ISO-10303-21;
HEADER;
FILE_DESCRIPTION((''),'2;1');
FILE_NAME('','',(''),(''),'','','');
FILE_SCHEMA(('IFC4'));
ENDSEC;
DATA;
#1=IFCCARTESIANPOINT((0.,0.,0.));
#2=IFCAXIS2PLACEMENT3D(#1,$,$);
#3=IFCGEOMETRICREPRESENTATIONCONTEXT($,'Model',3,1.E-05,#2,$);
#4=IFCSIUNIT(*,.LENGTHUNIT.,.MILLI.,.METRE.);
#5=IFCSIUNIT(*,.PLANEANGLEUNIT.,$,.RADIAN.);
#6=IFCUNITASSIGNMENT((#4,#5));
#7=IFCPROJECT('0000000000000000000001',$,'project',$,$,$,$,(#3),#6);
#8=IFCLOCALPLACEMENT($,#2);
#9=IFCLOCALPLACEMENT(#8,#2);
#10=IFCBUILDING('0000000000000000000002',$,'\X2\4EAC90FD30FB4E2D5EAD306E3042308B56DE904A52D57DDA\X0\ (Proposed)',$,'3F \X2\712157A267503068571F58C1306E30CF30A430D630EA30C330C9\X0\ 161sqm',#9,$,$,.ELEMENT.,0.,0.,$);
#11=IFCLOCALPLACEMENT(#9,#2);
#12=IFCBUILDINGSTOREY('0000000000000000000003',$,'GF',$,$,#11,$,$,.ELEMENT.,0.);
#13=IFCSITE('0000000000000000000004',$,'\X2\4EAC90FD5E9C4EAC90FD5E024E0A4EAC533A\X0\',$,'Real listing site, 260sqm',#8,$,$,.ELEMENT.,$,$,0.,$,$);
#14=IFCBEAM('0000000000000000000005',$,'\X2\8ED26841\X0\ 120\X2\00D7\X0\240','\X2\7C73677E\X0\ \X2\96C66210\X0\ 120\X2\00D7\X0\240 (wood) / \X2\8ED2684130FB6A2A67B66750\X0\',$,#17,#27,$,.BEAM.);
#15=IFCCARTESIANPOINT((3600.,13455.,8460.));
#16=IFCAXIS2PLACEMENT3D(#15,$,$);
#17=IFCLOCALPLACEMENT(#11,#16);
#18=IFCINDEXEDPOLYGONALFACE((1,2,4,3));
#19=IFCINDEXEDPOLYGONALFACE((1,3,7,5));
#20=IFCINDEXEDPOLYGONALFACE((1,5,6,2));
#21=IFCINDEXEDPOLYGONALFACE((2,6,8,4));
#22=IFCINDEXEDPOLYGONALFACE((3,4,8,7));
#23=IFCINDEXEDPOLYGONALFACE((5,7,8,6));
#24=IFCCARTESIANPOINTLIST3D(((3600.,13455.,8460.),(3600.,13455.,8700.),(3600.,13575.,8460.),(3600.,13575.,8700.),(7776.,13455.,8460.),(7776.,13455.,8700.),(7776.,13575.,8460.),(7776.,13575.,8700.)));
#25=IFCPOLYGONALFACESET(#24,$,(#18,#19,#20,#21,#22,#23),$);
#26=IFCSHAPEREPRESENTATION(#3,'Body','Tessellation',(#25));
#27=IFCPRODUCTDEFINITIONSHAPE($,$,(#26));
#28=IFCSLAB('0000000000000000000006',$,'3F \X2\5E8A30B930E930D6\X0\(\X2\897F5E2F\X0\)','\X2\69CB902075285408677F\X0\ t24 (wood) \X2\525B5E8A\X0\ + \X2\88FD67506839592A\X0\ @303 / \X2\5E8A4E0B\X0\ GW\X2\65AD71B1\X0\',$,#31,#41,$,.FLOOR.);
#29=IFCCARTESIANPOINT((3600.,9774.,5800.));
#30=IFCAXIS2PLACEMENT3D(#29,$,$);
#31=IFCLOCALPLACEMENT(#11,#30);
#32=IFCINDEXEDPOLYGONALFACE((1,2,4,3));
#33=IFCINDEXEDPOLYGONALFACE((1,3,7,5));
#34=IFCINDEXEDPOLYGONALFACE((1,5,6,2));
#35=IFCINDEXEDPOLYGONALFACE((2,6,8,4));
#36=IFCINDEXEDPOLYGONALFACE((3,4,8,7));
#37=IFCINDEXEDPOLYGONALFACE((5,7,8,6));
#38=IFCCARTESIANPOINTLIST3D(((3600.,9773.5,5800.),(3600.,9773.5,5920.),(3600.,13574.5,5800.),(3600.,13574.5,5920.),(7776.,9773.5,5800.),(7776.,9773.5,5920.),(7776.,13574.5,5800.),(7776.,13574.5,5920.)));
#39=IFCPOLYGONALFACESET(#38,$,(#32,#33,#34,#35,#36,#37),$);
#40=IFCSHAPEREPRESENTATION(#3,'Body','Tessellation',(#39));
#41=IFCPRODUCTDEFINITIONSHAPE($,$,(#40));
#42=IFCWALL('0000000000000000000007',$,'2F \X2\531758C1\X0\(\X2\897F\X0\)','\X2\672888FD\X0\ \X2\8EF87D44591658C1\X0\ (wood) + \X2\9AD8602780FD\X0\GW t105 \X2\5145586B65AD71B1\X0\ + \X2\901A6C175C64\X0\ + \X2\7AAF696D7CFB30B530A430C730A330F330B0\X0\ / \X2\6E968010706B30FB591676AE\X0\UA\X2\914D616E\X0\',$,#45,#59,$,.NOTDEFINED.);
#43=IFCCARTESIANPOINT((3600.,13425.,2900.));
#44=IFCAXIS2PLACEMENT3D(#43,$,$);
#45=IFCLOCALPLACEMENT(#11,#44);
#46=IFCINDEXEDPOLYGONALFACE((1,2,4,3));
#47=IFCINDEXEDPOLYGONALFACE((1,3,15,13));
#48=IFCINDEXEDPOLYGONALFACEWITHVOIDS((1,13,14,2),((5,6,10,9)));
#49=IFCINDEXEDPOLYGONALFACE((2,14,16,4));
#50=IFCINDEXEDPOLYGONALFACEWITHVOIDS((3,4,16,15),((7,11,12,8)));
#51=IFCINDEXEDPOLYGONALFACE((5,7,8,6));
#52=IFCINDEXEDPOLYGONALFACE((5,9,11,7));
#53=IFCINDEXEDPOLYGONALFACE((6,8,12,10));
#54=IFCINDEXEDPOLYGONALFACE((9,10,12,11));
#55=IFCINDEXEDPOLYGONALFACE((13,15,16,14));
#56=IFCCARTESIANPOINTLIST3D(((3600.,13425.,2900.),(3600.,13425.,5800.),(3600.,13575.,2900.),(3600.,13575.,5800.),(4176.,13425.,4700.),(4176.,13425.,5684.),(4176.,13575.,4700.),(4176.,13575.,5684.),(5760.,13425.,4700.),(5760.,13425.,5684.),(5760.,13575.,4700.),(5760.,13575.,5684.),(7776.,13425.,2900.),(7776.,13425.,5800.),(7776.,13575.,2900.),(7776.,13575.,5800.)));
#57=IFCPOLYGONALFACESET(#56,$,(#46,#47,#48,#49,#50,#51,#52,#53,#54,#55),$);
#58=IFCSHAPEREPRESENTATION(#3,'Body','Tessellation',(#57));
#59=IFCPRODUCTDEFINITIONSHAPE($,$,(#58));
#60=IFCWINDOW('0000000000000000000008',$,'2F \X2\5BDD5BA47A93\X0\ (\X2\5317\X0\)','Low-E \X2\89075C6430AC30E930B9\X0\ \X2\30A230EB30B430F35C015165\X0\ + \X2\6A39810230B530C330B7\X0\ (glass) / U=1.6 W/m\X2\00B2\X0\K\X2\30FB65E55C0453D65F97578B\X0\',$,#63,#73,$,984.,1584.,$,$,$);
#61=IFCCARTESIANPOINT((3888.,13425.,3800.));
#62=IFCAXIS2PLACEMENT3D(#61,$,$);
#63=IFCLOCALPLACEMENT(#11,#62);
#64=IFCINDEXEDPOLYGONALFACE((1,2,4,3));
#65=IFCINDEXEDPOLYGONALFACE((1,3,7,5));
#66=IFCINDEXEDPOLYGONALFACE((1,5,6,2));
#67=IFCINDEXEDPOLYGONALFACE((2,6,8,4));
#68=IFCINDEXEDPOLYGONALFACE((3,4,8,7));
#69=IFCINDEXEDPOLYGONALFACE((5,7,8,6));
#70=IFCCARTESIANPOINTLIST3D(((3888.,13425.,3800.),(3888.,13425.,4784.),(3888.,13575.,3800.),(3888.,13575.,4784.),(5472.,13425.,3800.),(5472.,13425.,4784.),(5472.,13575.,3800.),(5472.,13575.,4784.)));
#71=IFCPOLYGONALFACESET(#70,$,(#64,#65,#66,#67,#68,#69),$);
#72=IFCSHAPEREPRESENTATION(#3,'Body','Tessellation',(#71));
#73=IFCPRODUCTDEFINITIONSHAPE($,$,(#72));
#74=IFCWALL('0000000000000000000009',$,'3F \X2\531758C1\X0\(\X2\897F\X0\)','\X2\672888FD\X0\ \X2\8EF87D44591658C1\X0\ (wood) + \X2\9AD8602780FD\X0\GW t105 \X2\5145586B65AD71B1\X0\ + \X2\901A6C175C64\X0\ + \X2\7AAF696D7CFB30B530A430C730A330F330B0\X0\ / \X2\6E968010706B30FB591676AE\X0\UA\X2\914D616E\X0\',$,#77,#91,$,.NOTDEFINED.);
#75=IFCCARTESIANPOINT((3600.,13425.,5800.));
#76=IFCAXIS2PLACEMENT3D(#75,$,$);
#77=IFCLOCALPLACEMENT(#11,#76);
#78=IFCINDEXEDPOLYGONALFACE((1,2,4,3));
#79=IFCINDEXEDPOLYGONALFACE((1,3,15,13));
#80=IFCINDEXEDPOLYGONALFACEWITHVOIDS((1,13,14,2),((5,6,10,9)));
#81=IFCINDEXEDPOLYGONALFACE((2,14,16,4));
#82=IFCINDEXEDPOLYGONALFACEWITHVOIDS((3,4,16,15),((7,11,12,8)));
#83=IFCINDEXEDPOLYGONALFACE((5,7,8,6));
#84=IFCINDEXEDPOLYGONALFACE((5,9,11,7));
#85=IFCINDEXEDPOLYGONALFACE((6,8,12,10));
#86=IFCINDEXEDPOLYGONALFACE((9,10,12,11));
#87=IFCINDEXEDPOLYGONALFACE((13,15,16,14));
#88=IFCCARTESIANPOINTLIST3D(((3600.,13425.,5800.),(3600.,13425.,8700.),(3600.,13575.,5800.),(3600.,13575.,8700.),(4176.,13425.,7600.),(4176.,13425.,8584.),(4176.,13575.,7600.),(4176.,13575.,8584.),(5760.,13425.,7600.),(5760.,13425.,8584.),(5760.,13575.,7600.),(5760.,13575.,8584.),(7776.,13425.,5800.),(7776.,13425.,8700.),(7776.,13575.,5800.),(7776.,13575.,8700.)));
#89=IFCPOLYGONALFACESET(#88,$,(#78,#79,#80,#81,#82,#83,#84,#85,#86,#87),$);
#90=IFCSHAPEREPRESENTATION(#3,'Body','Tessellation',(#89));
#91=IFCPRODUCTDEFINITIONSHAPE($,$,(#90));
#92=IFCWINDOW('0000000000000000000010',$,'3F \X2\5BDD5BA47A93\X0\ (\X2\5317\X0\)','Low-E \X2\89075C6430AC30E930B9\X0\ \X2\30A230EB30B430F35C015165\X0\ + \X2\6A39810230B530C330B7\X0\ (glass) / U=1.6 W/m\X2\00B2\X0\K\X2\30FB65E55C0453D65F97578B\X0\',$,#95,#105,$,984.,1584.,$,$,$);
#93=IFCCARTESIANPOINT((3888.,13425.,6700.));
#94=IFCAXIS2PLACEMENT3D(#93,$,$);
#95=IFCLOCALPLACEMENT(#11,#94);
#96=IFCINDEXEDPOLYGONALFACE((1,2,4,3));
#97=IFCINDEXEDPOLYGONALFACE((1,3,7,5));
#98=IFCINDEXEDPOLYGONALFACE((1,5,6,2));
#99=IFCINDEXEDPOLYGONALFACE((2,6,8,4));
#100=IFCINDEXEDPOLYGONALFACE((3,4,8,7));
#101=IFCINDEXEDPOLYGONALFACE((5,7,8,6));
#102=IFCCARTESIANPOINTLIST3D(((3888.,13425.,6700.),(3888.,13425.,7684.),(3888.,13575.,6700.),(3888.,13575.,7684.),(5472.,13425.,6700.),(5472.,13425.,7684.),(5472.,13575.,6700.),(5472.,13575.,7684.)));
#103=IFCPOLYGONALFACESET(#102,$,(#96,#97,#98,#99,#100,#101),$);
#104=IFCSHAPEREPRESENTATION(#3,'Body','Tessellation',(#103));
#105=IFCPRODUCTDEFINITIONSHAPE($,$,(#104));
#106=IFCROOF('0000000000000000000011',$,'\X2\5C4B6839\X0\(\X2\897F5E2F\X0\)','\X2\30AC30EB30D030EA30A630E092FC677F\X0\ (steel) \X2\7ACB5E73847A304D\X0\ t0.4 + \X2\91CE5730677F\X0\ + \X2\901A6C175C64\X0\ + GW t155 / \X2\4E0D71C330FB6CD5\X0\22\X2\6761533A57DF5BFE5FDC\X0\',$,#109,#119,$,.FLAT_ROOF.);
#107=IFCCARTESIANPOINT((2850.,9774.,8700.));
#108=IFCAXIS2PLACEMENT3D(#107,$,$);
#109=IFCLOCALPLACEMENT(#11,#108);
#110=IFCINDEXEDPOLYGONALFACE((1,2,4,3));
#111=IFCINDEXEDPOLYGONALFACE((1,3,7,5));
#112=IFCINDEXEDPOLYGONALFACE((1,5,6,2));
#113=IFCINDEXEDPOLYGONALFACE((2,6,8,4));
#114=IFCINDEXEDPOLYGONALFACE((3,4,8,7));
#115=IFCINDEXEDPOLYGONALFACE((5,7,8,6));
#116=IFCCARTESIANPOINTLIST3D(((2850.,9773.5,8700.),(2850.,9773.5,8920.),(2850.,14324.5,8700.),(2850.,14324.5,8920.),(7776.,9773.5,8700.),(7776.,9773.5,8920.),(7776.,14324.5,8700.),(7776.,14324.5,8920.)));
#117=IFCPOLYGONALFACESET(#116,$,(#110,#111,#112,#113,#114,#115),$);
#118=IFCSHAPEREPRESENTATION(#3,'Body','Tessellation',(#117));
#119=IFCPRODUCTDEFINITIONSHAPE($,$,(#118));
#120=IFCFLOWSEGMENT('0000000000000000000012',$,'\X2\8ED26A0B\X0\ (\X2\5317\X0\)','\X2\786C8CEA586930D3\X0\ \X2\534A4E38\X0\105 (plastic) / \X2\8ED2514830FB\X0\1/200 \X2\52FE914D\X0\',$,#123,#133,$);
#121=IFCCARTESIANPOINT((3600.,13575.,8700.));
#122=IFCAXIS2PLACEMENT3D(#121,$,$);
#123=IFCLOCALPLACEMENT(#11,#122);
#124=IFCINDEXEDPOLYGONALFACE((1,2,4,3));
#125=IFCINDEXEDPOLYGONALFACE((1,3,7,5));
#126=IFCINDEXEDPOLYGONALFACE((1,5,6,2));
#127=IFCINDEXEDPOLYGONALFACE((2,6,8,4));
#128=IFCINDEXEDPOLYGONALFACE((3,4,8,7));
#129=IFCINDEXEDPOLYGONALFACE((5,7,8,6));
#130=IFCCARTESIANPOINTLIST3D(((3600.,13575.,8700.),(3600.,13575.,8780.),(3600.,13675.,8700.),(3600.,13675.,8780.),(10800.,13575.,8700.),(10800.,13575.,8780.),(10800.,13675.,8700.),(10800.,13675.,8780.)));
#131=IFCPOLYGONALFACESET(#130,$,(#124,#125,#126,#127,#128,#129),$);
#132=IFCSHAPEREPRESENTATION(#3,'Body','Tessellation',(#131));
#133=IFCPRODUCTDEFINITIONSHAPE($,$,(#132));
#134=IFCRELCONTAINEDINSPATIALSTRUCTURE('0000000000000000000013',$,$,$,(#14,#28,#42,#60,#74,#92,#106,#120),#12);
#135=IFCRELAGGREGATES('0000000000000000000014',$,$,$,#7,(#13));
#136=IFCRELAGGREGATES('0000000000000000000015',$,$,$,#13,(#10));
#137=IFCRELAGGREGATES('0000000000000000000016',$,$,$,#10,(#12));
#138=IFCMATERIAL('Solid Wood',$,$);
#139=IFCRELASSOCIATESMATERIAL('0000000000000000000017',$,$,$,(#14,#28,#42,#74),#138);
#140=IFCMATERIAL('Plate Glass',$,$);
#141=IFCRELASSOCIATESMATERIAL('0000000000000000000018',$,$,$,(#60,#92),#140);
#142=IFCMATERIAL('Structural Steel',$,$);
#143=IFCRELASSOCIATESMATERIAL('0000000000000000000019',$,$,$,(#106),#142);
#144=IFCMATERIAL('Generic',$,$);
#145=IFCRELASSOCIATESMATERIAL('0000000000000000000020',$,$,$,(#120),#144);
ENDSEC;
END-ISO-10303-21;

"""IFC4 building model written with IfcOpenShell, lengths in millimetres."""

from ifc_helpers import new_model, si_unit, frame, frame_2d, origin, place, context, project, spatial, rectangle, extrude, material, element, fill, save


model = new_model("IFC4")

# Units and contexts
model_context = context("Model", 3, precision=1e-05, world=origin())
ifc_project = project(units=[si_unit("LENGTHUNIT", "METRE", prefix="MILLI"), si_unit("PLANEANGLEUNIT", "RADIAN")], contexts=[model_context])

# Site, building, storey
site_placement = place(None, origin())
site = spatial("IfcSite", under=ifc_project, at=site_placement, Name="京都府京都市上京区", ObjectType="Real listing site, 260sqm", CompositionType="ELEMENT", RefElevation=0.0)
building_placement = place(site_placement, origin())
building = spatial("IfcBuilding", under=site, at=building_placement, Name="京都・中庭のある回遊動線 (Proposed)", ObjectType="3F 無垢材と土壁のハイブリッド 161sqm", CompositionType="ELEMENT", ElevationOfRefHeight=0.0, ElevationOfTerrain=0.0)
storey_placement = place(building_placement, origin())
storey = spatial("IfcBuildingStorey", under=building, at=storey_placement, Name="GF", CompositionType="ELEMENT", Elevation=0.0)

# Shared definitions
ifc_material_1 = material(Name="Solid Wood")

# Beam
beam_1_placement = place(storey_placement, frame((3600.0, 13455.0, 8460.0)))
element("IfcBeam", 1, at=beam_1_placement, inside=storey, material=ifc_material_1, Name="軒桁 120×240", Description="米松 集成 120×240 (wood) / 軒桁・横架材", PredefinedType="BEAM", context=model_context, shape_type="SweptSolid", body=[
    extrude(rectangle(XDim=4176.0, YDim=120.0, at=frame_2d((2088.0, 60.0))), frame((3600.0, 13455.0, 8460.0)), (0.0, 0.0, 1.0), 240.0),
])

# Slab
slab_placement = place(storey_placement, frame((3600.0, 9774.0, 5800.0)))
element("IfcSlab", 2, at=slab_placement, inside=storey, material=ifc_material_1, Name="3F 床スラブ(西帯)", Description="構造用合板 t24 (wood) 剛床 + 製材根太 @303 / 床下 GW断熱", PredefinedType="FLOOR", context=model_context, shape_type="SweptSolid", body=[
    extrude(rectangle(XDim=4176.0, YDim=3801.0, at=frame_2d((2088.0, 1900.0))), frame((3600.0, 9774.0, 5800.0)), (0.0, 0.0, 1.0), 120.0),
])

# Walls, openings, windows
wall_1_placement = place(storey_placement, frame((3600.0, 13425.0, 2900.0)))
wall_1 = element("IfcWall", 3, at=wall_1_placement, inside=storey, material=ifc_material_1, Name="2F 北壁(西)", Description="木製 軸組外壁 (wood) + 高性能GW t105 充填断熱 + 通気層 + 窯業系サイディング / 準耐火・外皮UA配慮", PredefinedType="NOTDEFINED", context=model_context, shape_type="SweptSolid", body=[
    extrude(rectangle(XDim=4176.0, YDim=150.0, at=frame_2d((2088.0, 75.0))), frame((3600.0, 13425.0, 2900.0)), (0.0, 0.0, 1.0), 2900.0),
])
opening_1_placement = place(storey_placement, frame((3888.0, 13425.0, 3800.0)))
opening_1 = element("IfcOpeningElement", 4, at=opening_1_placement, cuts=wall_1, PredefinedType="NOTDEFINED", context=model_context, shape_type="SweptSolid", body=[
    extrude(rectangle(XDim=1584.0, YDim=150.0, at=frame_2d((792.0, 75.0))), frame((3888.0, 13425.0, 3800.0)), (0.0, 0.0, 1.0), 984.0),
])
ifc_material_2 = material(Name="Plate Glass")
window_1_placement = place(storey_placement, frame((3888.0, 13425.0, 3800.0)))
window_1 = element("IfcWindow", 5, at=window_1_placement, inside=storey, material=ifc_material_2, Name="2F 寝室窓 (北)", Description="Low-E 複層ガラス アルゴン封入 + 樹脂サッシ (glass) / U=1.6 W/m²K・日射取得型", OverallHeight=984.0, OverallWidth=1584.0, context=model_context, shape_type="SweptSolid", body=[
    extrude(rectangle(XDim=1584.0, YDim=150.0, at=frame_2d((792.0, 75.0))), frame((3888.0, 13425.0, 3800.0)), (0.0, 0.0, 1.0), 984.0),
])
fill(opening_1, window_1)
wall_2_placement = place(storey_placement, frame((3600.0, 13425.0, 5800.0)))
wall_2 = element("IfcWall", 6, at=wall_2_placement, inside=storey, material=ifc_material_1, Name="3F 北壁(西)", Description="木製 軸組外壁 (wood) + 高性能GW t105 充填断熱 + 通気層 + 窯業系サイディング / 準耐火・外皮UA配慮", PredefinedType="NOTDEFINED", context=model_context, shape_type="SweptSolid", body=[
    extrude(rectangle(XDim=4176.0, YDim=150.0, at=frame_2d((2088.0, 75.0))), frame((3600.0, 13425.0, 5800.0)), (0.0, 0.0, 1.0), 2900.0),
])
opening_2_placement = place(storey_placement, frame((3888.0, 13425.0, 6700.0)))
opening_2 = element("IfcOpeningElement", 7, at=opening_2_placement, cuts=wall_2, PredefinedType="NOTDEFINED", context=model_context, shape_type="SweptSolid", body=[
    extrude(rectangle(XDim=1584.0, YDim=150.0, at=frame_2d((792.0, 75.0))), frame((3888.0, 13425.0, 6700.0)), (0.0, 0.0, 1.0), 984.0),
])
window_2_placement = place(storey_placement, frame((3888.0, 13425.0, 6700.0)))
window_2 = element("IfcWindow", 8, at=window_2_placement, inside=storey, material=ifc_material_2, Name="3F 寝室窓 (北)", Description="Low-E 複層ガラス アルゴン封入 + 樹脂サッシ (glass) / U=1.6 W/m²K・日射取得型", OverallHeight=984.0, OverallWidth=1584.0, context=model_context, shape_type="SweptSolid", body=[
    extrude(rectangle(XDim=1584.0, YDim=150.0, at=frame_2d((792.0, 75.0))), frame((3888.0, 13425.0, 6700.0)), (0.0, 0.0, 1.0), 984.0),
])
fill(opening_2, window_2)

# Roof
ifc_material_3 = material(Name="Structural Steel")
for number, where, name in (
    (9, (2850.0, 9774.0, 8700.0), "屋根(西帯)"),
):
    element("IfcRoof", number, at=place(storey_placement, frame(where)), inside=storey, material=ifc_material_3, Name=name, Description="ガルバリウム鋼板 (steel) 立平葺き t0.4 + 野地板 + 通気層 + GW t155 / 不燃・法22条区域対応", PredefinedType="FLAT_ROOF", context=model_context, shape_type="SweptSolid", body=[
        extrude(rectangle(XDim=4926.0, YDim=4551.0, at=frame_2d((2463.0, 2275.0))), frame((2850.0, 9774.0, 8700.0)), (0.0, 0.0, 1.0), 220.0),
    ])

# Flow segment
ifc_material_4 = material(Name="Generic")
flow_segment_placement = place(storey_placement, frame((3600.0, 13575.0, 8700.0)))
element("IfcFlowSegment", 10, at=flow_segment_placement, inside=storey, material=ifc_material_4, Name="軒樋 (北)", Description="硬質塩ビ 半丸105 (plastic) / 軒先・1/200 勾配", context=model_context, shape_type="SweptSolid", body=[
    extrude(rectangle(XDim=7200.0, YDim=100.0, at=frame_2d((3600.0, 50.0))), frame((3600.0, 13575.0, 8700.0)), (0.0, 0.0, 1.0), 80.0),
])

save(model, "model.ifc")
